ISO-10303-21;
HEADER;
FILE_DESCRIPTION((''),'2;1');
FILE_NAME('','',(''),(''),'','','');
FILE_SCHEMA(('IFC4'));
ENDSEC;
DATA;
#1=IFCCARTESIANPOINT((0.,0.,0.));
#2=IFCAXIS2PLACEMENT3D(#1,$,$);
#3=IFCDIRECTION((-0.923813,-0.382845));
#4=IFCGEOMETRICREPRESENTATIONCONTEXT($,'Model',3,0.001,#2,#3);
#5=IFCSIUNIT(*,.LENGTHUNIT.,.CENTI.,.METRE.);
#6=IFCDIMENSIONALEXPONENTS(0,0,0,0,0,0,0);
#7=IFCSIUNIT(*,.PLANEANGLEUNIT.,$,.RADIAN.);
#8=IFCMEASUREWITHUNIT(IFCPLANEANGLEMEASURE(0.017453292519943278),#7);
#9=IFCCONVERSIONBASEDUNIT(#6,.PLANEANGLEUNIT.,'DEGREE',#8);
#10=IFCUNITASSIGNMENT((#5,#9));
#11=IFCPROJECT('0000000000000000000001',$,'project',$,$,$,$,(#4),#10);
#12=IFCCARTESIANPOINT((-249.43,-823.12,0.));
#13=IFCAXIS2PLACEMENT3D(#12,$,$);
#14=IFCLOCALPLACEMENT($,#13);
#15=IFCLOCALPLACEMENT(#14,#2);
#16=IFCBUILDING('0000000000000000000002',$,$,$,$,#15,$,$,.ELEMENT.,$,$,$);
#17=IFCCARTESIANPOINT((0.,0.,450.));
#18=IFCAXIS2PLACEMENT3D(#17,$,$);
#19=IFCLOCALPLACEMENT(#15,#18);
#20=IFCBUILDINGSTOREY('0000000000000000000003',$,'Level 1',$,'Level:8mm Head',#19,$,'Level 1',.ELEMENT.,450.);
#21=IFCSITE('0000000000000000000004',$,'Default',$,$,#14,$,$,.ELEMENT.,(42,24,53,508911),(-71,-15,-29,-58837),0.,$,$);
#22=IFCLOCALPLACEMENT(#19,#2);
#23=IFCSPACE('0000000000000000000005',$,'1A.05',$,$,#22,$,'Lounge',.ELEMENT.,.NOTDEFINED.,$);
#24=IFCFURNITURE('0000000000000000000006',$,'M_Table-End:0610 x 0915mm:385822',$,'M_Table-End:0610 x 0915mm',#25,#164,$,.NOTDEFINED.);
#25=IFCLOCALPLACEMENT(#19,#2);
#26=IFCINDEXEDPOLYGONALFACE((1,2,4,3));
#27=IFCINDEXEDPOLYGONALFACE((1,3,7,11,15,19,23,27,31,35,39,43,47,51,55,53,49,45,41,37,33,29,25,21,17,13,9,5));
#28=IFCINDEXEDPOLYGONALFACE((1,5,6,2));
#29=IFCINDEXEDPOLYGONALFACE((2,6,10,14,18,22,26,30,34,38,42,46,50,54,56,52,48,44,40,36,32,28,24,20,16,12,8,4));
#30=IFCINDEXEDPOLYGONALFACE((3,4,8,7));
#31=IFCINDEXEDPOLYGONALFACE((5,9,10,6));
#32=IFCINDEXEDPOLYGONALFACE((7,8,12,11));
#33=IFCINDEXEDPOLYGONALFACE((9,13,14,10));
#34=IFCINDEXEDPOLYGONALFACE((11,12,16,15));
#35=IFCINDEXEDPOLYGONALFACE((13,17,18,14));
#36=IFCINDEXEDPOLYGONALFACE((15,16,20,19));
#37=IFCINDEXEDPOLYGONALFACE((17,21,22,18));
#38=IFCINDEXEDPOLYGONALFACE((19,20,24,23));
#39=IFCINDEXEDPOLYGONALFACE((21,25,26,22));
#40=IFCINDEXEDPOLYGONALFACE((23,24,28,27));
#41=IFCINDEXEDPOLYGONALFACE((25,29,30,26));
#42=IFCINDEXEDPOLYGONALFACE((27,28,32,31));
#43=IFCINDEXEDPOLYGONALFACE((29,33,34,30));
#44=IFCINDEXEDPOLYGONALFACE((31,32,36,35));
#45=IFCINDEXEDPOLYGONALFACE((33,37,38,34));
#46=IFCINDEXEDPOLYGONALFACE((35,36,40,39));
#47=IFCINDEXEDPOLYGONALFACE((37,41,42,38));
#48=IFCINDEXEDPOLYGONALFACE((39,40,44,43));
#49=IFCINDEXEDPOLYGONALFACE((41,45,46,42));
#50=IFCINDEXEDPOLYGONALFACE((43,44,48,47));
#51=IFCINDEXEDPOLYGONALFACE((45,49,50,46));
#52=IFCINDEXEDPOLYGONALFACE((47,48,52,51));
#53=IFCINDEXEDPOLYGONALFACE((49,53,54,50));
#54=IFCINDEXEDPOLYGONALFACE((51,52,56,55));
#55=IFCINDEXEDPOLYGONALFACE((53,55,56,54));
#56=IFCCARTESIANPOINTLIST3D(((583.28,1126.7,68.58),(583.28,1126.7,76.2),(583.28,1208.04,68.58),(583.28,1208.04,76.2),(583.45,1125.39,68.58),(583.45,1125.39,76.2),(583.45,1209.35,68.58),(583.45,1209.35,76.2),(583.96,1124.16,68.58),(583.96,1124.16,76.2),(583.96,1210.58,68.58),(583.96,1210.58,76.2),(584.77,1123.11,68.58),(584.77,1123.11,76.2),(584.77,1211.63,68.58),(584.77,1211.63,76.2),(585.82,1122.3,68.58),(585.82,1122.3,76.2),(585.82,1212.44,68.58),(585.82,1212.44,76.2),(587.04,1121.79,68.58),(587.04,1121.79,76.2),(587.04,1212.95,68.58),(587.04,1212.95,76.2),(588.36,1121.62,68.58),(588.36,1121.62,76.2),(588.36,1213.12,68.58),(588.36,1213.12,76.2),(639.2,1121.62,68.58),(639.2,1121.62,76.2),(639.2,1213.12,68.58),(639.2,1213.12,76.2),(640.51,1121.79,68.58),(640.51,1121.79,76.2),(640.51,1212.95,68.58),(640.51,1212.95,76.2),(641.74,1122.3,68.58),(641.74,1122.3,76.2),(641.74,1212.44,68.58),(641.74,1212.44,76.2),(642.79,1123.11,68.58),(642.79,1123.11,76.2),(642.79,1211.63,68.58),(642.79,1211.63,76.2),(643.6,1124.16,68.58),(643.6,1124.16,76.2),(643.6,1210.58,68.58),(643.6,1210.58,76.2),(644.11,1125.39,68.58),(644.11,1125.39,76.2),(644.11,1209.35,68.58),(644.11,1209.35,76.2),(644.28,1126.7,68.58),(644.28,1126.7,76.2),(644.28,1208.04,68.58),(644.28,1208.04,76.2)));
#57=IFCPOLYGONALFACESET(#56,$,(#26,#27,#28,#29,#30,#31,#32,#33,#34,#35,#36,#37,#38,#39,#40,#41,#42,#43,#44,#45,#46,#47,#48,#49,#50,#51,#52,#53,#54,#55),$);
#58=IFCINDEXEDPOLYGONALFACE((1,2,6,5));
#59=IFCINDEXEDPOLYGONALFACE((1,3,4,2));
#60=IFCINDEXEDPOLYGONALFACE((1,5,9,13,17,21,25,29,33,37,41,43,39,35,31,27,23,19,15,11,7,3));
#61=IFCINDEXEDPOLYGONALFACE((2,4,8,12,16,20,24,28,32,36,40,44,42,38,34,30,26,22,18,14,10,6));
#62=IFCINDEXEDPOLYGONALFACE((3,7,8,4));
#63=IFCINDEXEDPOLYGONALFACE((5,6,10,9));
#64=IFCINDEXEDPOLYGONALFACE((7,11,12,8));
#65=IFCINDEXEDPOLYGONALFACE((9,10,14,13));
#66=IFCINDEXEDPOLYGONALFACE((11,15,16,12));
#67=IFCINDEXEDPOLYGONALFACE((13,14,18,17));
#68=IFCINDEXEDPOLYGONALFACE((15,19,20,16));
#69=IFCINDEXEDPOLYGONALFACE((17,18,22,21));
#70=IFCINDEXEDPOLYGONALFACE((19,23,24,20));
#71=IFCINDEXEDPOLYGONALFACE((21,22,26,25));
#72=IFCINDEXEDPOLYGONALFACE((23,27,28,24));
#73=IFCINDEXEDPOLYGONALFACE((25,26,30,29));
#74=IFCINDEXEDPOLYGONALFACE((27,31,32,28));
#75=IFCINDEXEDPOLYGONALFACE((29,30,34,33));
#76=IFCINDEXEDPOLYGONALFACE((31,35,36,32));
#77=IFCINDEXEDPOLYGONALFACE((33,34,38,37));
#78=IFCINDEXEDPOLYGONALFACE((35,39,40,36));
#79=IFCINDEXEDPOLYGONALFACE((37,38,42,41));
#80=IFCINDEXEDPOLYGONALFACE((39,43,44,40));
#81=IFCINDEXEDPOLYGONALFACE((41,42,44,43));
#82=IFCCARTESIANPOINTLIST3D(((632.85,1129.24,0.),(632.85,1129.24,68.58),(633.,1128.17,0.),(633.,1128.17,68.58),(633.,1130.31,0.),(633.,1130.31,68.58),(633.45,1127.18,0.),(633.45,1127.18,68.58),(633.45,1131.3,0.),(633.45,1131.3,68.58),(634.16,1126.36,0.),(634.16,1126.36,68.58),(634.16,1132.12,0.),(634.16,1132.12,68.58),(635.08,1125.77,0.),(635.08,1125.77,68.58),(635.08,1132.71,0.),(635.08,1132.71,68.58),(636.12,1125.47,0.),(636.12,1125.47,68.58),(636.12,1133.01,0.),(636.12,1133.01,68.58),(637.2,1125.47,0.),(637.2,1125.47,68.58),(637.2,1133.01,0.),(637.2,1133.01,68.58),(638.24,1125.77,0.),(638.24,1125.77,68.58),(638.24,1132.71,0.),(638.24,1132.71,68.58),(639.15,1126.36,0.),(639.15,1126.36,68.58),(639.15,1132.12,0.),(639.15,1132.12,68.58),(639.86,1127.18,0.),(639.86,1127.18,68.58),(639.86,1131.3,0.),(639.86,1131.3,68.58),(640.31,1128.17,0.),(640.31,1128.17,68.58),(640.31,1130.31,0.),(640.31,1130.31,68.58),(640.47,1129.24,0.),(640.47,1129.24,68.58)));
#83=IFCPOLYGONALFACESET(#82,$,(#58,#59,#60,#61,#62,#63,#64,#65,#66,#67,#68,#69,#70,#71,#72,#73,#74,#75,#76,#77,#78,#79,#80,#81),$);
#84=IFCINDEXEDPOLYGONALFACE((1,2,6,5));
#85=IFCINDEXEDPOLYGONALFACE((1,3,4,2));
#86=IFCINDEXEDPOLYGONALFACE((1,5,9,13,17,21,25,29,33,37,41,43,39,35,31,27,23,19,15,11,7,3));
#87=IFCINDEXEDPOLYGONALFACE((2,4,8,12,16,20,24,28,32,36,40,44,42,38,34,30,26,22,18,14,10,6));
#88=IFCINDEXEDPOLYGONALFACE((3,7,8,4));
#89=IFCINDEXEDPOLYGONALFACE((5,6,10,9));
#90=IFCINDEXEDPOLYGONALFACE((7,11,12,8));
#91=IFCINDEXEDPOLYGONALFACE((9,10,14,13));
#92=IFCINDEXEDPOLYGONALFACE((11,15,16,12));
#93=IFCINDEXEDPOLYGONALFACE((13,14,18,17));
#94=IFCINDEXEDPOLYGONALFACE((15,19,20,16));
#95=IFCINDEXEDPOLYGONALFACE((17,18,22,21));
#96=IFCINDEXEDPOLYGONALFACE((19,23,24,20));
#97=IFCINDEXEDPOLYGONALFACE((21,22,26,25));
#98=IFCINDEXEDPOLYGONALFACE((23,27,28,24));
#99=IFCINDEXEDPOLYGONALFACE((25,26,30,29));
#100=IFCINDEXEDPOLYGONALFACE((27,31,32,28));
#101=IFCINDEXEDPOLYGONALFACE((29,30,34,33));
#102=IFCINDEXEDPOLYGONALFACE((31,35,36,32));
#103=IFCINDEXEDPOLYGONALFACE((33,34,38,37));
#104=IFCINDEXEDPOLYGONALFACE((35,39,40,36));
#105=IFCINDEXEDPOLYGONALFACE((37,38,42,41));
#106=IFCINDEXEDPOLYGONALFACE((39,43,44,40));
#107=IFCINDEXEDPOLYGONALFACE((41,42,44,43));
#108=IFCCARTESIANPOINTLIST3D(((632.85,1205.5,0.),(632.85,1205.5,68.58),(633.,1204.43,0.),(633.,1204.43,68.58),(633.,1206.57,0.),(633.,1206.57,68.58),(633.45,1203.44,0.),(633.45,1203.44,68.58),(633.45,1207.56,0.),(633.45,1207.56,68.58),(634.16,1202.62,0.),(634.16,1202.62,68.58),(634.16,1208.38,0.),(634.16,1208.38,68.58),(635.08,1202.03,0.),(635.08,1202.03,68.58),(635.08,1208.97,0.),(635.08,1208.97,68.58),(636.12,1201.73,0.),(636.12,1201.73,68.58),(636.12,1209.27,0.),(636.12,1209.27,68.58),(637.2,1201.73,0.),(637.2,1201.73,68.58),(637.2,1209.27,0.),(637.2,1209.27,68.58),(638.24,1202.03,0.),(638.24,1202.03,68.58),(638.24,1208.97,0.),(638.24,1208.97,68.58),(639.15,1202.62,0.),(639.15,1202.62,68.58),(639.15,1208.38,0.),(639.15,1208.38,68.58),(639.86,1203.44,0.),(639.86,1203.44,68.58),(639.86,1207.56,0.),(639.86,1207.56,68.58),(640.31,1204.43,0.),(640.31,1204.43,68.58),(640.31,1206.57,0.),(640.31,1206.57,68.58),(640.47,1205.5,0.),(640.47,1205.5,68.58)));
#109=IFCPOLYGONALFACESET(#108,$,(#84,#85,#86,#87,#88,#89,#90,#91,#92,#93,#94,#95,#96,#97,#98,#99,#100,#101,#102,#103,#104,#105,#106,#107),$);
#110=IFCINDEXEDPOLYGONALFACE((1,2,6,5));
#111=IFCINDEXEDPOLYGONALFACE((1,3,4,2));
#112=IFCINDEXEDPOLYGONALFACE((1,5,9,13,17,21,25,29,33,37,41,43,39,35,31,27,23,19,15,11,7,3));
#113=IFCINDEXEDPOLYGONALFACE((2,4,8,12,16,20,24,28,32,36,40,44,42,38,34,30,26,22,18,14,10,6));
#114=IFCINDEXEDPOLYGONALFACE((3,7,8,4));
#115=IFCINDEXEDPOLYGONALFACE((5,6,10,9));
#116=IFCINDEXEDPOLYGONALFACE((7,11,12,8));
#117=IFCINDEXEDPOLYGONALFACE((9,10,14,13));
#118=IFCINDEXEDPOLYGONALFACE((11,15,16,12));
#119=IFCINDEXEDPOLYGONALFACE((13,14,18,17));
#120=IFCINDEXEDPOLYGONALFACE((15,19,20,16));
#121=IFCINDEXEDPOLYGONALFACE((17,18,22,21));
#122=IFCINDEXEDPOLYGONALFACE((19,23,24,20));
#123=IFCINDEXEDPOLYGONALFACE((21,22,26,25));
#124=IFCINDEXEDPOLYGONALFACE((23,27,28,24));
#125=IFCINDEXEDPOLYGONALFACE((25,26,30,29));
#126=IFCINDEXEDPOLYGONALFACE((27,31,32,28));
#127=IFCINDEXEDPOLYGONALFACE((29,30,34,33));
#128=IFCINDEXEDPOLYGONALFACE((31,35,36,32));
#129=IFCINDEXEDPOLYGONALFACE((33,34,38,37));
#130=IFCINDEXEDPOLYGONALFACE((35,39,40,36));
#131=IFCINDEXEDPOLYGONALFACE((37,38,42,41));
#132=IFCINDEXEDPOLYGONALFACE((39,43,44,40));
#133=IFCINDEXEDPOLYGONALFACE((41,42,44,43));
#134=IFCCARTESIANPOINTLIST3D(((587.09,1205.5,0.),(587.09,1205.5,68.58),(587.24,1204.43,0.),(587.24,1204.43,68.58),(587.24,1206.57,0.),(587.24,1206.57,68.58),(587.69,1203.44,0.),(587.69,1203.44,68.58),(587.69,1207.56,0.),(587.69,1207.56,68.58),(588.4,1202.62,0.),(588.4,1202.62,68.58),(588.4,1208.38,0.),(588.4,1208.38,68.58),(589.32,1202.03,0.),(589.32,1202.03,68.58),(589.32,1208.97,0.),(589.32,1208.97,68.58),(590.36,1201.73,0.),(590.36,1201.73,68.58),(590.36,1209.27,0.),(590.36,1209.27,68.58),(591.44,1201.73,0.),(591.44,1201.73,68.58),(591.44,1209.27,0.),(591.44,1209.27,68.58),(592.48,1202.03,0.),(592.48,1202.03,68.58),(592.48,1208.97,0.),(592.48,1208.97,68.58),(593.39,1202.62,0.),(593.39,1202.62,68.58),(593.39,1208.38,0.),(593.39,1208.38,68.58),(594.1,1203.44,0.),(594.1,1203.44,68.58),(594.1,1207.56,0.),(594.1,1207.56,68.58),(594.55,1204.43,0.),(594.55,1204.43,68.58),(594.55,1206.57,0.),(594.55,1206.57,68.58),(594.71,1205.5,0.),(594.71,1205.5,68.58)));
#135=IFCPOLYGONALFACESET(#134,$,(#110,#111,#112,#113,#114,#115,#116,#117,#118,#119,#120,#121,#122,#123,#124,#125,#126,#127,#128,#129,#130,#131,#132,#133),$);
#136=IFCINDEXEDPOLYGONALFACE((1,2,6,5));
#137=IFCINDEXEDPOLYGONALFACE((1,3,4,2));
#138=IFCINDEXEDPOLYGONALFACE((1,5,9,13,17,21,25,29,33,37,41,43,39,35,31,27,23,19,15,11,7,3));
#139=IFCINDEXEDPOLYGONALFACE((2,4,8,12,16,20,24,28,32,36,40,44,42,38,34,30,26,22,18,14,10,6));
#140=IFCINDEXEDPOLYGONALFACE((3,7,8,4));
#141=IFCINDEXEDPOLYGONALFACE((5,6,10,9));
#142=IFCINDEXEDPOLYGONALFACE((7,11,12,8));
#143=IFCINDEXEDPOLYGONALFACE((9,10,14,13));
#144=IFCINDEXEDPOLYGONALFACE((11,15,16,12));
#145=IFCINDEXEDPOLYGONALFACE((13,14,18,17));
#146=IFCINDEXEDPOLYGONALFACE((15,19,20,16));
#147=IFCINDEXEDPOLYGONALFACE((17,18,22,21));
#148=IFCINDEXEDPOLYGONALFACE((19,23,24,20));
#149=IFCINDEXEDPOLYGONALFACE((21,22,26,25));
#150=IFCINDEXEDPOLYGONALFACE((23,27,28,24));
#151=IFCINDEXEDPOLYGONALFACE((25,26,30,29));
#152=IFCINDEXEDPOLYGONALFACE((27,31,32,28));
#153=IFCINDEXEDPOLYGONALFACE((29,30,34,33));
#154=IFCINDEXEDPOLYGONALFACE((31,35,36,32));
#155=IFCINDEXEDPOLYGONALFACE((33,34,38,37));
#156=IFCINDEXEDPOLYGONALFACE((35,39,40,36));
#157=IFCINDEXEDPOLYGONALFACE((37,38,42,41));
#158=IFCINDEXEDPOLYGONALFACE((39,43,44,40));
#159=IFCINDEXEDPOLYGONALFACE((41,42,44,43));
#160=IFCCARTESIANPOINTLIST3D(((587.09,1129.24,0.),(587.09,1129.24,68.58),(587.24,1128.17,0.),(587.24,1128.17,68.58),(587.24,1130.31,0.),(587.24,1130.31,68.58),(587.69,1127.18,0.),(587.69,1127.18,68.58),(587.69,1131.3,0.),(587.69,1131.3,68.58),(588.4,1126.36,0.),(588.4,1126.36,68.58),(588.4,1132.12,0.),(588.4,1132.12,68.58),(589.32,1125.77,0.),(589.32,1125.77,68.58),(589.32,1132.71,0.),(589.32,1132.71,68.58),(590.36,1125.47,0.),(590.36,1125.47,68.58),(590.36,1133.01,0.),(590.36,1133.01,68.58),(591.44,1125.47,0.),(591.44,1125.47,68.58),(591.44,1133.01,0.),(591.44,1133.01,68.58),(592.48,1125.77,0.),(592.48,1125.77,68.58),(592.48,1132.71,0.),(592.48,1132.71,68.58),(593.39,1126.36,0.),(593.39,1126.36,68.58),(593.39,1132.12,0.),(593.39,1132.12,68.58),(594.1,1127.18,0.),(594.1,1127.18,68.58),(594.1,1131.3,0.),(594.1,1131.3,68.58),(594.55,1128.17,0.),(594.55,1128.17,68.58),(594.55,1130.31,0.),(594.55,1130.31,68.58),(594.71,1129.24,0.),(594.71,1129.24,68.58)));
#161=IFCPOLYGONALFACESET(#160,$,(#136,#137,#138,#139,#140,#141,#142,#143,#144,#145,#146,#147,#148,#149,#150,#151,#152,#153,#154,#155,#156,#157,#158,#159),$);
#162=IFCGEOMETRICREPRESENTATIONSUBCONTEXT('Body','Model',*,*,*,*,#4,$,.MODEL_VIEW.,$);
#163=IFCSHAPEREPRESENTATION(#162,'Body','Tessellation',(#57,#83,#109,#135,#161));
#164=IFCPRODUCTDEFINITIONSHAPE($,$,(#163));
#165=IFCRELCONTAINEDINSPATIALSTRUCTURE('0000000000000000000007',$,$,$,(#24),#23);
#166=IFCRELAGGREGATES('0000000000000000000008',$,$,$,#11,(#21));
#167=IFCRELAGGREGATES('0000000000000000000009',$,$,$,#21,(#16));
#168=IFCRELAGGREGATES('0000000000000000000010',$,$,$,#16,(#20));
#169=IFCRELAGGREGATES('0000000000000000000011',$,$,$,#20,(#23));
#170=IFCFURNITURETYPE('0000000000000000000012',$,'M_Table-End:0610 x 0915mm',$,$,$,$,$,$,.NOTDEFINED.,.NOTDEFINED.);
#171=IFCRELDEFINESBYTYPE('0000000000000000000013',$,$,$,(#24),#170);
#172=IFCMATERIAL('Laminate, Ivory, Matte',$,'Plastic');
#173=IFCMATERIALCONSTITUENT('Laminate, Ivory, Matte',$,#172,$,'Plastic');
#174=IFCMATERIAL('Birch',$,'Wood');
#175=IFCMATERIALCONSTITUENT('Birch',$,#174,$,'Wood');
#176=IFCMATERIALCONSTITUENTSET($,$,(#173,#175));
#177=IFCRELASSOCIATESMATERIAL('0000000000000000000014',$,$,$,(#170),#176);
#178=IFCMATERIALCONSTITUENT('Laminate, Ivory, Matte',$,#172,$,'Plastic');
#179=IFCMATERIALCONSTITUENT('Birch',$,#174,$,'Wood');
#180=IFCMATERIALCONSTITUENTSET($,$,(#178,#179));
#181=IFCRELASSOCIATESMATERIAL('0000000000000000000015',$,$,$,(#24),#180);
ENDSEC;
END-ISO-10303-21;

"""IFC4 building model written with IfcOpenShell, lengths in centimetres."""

from ifc_helpers import new_model, entity, si_unit, converted_unit, direction, frame, origin, place, context, subcontext, project, spatial, line, arc, indexed_curve, outline, extrude, source, transform, mapped, material, constituent, constituent_set, type_object, type_shapes, element, save


model = new_model("IFC4")

# Units and contexts
model_context = context("Model", 3, precision=0.001, world=origin(), true_north=direction((-0.923813, -0.382845)))
body_context = subcontext(model_context, "Body", "Model", "MODEL_VIEW")
ifc_project = project(units=[si_unit("LENGTHUNIT", "METRE", prefix="CENTI"), converted_unit("PLANEANGLEUNIT", "DEGREE", entity("IfcPlaneAngleMeasure", 0.017453292519943278), si_unit("PLANEANGLEUNIT", "RADIAN"), dimensions=[0, 0, 0, 0, 0, 0, 0])], contexts=[model_context])

# Site, building, storey
site_placement = place(None, frame((-249.43, -823.12, 0.0)))
site = spatial("IfcSite", under=ifc_project, at=site_placement, Name="Default", CompositionType="ELEMENT", RefLatitude=(42, 24, 53, 508911), RefLongitude=(-71, -15, -29, -58837), RefElevation=0.0)
building_placement = place(site_placement, origin())
building = spatial("IfcBuilding", under=site, at=building_placement, CompositionType="ELEMENT")
storey_placement = place(building_placement, frame((0.0, 0.0, 450.0)))
storey = spatial("IfcBuildingStorey", under=building, at=storey_placement, Name="Level 1", ObjectType="Level:8mm Head", LongName="Level 1", CompositionType="ELEMENT", Elevation=450.0)

# Shared definitions
space_1_placement = place(storey_placement, origin())
space_1 = spatial("IfcSpace", under=storey, at=space_1_placement, Name="1A.05", LongName="Lounge", CompositionType="ELEMENT", PredefinedType="NOTDEFINED")

# Furniture
ifc_material_1 = material(Name="Laminate, Ivory, Matte", Category="Plastic")
ifc_constituent_1 = constituent(ifc_material_1, Name="Laminate, Ivory, Matte", Category="Plastic")
ifc_material_2 = material(Name="Birch", Category="Wood")
ifc_constituent_2 = constituent(ifc_material_2, Name="Birch", Category="Wood")
ifc_constituent_set_1 = constituent_set(constituents=[ifc_constituent_1, ifc_constituent_2])
ifc_constituent_3 = constituent(ifc_material_1, Name="Laminate, Ivory, Matte", Category="Plastic")
ifc_constituent_4 = constituent(ifc_material_2, Name="Birch", Category="Wood")
ifc_constituent_set_2 = constituent_set(constituents=[ifc_constituent_3, ifc_constituent_4])
furniture_type_1 = type_object("IfcFurnitureType", Name="M_Table-End:0610 x 0915mm", AssemblyPlace="NOTDEFINED", PredefinedType="NOTDEFINED", material=ifc_constituent_set_2)
shared_shape_1 = source(origin(), body_context, "Body", "SweptSolid", [
    extrude(outline(indexed_curve([(25.42, -45.75), (29.01, -44.26), (30.5, -40.67), (30.5, 40.67), (29.01, 44.26), (25.42, 45.75), (-25.42, 45.75), (-29.01, 44.26), (-30.5, 40.67), (-30.5, -40.67), (-29.01, -44.26), (-25.42, -45.75)], segments=[arc(1, 2, 3), line(3, 4), arc(4, 5, 6), line(6, 7), arc(7, 8, 9), line(9, 10), arc(10, 11, 12), line(12, 1)], self_intersect=False)), frame((30.87, 15.24, -381.42)), (0.0, 0.0, 1.0), 7.62),
    extrude(outline(indexed_curve([(-3.81, 0.0), (0.0, -3.81), (3.81, 0.0), (0.0, 3.81)], segments=[arc(1, 2, 3), arc(3, 4, 1)], self_intersect=False)), frame((53.75, -22.89, -450.0)), (0.0, 0.0, 1.0), 68.58),
    extrude(outline(indexed_curve([(-3.81, 0.0), (0.0, -3.81), (3.81, 0.0), (0.0, 3.81)], segments=[arc(1, 2, 3), arc(3, 4, 1)], self_intersect=False)), frame((53.75, 53.37, -450.0)), (0.0, 0.0, 1.0), 68.58),
    extrude(outline(indexed_curve([(-3.81, 0.0), (0.0, -3.81), (3.81, 0.0), (0.0, 3.81)], segments=[arc(1, 2, 3), arc(3, 4, 1)], self_intersect=False)), frame((7.99, 53.37, -450.0)), (0.0, 0.0, 1.0), 68.58),
    extrude(outline(indexed_curve([(-3.81, 0.0), (0.0, -3.81), (3.81, 0.0), (0.0, 3.81)], segments=[arc(1, 2, 3), arc(3, 4, 1)], self_intersect=False)), frame((7.99, -22.89, -450.0)), (0.0, 0.0, 1.0), 68.58),
])
type_shapes(furniture_type_1, [shared_shape_1])
furniture_1_placement = place(space_1_placement, frame((582.9, 1152.13, 450.0)))
element("IfcFurniture", 1, at=furniture_1_placement, inside=space_1, type_object=furniture_type_1, material=ifc_constituent_set_1, Name="M_Table-End:0610 x 0915mm:385822", ObjectType="M_Table-End:0610 x 0915mm", PredefinedType="NOTDEFINED", context=body_context, shape_type="MappedRepresentation", body=[
    mapped(shared_shape_1, transform((0.0, 0.0, 0.0), scale=1.0)),
])

save(model, "model.ifc")
